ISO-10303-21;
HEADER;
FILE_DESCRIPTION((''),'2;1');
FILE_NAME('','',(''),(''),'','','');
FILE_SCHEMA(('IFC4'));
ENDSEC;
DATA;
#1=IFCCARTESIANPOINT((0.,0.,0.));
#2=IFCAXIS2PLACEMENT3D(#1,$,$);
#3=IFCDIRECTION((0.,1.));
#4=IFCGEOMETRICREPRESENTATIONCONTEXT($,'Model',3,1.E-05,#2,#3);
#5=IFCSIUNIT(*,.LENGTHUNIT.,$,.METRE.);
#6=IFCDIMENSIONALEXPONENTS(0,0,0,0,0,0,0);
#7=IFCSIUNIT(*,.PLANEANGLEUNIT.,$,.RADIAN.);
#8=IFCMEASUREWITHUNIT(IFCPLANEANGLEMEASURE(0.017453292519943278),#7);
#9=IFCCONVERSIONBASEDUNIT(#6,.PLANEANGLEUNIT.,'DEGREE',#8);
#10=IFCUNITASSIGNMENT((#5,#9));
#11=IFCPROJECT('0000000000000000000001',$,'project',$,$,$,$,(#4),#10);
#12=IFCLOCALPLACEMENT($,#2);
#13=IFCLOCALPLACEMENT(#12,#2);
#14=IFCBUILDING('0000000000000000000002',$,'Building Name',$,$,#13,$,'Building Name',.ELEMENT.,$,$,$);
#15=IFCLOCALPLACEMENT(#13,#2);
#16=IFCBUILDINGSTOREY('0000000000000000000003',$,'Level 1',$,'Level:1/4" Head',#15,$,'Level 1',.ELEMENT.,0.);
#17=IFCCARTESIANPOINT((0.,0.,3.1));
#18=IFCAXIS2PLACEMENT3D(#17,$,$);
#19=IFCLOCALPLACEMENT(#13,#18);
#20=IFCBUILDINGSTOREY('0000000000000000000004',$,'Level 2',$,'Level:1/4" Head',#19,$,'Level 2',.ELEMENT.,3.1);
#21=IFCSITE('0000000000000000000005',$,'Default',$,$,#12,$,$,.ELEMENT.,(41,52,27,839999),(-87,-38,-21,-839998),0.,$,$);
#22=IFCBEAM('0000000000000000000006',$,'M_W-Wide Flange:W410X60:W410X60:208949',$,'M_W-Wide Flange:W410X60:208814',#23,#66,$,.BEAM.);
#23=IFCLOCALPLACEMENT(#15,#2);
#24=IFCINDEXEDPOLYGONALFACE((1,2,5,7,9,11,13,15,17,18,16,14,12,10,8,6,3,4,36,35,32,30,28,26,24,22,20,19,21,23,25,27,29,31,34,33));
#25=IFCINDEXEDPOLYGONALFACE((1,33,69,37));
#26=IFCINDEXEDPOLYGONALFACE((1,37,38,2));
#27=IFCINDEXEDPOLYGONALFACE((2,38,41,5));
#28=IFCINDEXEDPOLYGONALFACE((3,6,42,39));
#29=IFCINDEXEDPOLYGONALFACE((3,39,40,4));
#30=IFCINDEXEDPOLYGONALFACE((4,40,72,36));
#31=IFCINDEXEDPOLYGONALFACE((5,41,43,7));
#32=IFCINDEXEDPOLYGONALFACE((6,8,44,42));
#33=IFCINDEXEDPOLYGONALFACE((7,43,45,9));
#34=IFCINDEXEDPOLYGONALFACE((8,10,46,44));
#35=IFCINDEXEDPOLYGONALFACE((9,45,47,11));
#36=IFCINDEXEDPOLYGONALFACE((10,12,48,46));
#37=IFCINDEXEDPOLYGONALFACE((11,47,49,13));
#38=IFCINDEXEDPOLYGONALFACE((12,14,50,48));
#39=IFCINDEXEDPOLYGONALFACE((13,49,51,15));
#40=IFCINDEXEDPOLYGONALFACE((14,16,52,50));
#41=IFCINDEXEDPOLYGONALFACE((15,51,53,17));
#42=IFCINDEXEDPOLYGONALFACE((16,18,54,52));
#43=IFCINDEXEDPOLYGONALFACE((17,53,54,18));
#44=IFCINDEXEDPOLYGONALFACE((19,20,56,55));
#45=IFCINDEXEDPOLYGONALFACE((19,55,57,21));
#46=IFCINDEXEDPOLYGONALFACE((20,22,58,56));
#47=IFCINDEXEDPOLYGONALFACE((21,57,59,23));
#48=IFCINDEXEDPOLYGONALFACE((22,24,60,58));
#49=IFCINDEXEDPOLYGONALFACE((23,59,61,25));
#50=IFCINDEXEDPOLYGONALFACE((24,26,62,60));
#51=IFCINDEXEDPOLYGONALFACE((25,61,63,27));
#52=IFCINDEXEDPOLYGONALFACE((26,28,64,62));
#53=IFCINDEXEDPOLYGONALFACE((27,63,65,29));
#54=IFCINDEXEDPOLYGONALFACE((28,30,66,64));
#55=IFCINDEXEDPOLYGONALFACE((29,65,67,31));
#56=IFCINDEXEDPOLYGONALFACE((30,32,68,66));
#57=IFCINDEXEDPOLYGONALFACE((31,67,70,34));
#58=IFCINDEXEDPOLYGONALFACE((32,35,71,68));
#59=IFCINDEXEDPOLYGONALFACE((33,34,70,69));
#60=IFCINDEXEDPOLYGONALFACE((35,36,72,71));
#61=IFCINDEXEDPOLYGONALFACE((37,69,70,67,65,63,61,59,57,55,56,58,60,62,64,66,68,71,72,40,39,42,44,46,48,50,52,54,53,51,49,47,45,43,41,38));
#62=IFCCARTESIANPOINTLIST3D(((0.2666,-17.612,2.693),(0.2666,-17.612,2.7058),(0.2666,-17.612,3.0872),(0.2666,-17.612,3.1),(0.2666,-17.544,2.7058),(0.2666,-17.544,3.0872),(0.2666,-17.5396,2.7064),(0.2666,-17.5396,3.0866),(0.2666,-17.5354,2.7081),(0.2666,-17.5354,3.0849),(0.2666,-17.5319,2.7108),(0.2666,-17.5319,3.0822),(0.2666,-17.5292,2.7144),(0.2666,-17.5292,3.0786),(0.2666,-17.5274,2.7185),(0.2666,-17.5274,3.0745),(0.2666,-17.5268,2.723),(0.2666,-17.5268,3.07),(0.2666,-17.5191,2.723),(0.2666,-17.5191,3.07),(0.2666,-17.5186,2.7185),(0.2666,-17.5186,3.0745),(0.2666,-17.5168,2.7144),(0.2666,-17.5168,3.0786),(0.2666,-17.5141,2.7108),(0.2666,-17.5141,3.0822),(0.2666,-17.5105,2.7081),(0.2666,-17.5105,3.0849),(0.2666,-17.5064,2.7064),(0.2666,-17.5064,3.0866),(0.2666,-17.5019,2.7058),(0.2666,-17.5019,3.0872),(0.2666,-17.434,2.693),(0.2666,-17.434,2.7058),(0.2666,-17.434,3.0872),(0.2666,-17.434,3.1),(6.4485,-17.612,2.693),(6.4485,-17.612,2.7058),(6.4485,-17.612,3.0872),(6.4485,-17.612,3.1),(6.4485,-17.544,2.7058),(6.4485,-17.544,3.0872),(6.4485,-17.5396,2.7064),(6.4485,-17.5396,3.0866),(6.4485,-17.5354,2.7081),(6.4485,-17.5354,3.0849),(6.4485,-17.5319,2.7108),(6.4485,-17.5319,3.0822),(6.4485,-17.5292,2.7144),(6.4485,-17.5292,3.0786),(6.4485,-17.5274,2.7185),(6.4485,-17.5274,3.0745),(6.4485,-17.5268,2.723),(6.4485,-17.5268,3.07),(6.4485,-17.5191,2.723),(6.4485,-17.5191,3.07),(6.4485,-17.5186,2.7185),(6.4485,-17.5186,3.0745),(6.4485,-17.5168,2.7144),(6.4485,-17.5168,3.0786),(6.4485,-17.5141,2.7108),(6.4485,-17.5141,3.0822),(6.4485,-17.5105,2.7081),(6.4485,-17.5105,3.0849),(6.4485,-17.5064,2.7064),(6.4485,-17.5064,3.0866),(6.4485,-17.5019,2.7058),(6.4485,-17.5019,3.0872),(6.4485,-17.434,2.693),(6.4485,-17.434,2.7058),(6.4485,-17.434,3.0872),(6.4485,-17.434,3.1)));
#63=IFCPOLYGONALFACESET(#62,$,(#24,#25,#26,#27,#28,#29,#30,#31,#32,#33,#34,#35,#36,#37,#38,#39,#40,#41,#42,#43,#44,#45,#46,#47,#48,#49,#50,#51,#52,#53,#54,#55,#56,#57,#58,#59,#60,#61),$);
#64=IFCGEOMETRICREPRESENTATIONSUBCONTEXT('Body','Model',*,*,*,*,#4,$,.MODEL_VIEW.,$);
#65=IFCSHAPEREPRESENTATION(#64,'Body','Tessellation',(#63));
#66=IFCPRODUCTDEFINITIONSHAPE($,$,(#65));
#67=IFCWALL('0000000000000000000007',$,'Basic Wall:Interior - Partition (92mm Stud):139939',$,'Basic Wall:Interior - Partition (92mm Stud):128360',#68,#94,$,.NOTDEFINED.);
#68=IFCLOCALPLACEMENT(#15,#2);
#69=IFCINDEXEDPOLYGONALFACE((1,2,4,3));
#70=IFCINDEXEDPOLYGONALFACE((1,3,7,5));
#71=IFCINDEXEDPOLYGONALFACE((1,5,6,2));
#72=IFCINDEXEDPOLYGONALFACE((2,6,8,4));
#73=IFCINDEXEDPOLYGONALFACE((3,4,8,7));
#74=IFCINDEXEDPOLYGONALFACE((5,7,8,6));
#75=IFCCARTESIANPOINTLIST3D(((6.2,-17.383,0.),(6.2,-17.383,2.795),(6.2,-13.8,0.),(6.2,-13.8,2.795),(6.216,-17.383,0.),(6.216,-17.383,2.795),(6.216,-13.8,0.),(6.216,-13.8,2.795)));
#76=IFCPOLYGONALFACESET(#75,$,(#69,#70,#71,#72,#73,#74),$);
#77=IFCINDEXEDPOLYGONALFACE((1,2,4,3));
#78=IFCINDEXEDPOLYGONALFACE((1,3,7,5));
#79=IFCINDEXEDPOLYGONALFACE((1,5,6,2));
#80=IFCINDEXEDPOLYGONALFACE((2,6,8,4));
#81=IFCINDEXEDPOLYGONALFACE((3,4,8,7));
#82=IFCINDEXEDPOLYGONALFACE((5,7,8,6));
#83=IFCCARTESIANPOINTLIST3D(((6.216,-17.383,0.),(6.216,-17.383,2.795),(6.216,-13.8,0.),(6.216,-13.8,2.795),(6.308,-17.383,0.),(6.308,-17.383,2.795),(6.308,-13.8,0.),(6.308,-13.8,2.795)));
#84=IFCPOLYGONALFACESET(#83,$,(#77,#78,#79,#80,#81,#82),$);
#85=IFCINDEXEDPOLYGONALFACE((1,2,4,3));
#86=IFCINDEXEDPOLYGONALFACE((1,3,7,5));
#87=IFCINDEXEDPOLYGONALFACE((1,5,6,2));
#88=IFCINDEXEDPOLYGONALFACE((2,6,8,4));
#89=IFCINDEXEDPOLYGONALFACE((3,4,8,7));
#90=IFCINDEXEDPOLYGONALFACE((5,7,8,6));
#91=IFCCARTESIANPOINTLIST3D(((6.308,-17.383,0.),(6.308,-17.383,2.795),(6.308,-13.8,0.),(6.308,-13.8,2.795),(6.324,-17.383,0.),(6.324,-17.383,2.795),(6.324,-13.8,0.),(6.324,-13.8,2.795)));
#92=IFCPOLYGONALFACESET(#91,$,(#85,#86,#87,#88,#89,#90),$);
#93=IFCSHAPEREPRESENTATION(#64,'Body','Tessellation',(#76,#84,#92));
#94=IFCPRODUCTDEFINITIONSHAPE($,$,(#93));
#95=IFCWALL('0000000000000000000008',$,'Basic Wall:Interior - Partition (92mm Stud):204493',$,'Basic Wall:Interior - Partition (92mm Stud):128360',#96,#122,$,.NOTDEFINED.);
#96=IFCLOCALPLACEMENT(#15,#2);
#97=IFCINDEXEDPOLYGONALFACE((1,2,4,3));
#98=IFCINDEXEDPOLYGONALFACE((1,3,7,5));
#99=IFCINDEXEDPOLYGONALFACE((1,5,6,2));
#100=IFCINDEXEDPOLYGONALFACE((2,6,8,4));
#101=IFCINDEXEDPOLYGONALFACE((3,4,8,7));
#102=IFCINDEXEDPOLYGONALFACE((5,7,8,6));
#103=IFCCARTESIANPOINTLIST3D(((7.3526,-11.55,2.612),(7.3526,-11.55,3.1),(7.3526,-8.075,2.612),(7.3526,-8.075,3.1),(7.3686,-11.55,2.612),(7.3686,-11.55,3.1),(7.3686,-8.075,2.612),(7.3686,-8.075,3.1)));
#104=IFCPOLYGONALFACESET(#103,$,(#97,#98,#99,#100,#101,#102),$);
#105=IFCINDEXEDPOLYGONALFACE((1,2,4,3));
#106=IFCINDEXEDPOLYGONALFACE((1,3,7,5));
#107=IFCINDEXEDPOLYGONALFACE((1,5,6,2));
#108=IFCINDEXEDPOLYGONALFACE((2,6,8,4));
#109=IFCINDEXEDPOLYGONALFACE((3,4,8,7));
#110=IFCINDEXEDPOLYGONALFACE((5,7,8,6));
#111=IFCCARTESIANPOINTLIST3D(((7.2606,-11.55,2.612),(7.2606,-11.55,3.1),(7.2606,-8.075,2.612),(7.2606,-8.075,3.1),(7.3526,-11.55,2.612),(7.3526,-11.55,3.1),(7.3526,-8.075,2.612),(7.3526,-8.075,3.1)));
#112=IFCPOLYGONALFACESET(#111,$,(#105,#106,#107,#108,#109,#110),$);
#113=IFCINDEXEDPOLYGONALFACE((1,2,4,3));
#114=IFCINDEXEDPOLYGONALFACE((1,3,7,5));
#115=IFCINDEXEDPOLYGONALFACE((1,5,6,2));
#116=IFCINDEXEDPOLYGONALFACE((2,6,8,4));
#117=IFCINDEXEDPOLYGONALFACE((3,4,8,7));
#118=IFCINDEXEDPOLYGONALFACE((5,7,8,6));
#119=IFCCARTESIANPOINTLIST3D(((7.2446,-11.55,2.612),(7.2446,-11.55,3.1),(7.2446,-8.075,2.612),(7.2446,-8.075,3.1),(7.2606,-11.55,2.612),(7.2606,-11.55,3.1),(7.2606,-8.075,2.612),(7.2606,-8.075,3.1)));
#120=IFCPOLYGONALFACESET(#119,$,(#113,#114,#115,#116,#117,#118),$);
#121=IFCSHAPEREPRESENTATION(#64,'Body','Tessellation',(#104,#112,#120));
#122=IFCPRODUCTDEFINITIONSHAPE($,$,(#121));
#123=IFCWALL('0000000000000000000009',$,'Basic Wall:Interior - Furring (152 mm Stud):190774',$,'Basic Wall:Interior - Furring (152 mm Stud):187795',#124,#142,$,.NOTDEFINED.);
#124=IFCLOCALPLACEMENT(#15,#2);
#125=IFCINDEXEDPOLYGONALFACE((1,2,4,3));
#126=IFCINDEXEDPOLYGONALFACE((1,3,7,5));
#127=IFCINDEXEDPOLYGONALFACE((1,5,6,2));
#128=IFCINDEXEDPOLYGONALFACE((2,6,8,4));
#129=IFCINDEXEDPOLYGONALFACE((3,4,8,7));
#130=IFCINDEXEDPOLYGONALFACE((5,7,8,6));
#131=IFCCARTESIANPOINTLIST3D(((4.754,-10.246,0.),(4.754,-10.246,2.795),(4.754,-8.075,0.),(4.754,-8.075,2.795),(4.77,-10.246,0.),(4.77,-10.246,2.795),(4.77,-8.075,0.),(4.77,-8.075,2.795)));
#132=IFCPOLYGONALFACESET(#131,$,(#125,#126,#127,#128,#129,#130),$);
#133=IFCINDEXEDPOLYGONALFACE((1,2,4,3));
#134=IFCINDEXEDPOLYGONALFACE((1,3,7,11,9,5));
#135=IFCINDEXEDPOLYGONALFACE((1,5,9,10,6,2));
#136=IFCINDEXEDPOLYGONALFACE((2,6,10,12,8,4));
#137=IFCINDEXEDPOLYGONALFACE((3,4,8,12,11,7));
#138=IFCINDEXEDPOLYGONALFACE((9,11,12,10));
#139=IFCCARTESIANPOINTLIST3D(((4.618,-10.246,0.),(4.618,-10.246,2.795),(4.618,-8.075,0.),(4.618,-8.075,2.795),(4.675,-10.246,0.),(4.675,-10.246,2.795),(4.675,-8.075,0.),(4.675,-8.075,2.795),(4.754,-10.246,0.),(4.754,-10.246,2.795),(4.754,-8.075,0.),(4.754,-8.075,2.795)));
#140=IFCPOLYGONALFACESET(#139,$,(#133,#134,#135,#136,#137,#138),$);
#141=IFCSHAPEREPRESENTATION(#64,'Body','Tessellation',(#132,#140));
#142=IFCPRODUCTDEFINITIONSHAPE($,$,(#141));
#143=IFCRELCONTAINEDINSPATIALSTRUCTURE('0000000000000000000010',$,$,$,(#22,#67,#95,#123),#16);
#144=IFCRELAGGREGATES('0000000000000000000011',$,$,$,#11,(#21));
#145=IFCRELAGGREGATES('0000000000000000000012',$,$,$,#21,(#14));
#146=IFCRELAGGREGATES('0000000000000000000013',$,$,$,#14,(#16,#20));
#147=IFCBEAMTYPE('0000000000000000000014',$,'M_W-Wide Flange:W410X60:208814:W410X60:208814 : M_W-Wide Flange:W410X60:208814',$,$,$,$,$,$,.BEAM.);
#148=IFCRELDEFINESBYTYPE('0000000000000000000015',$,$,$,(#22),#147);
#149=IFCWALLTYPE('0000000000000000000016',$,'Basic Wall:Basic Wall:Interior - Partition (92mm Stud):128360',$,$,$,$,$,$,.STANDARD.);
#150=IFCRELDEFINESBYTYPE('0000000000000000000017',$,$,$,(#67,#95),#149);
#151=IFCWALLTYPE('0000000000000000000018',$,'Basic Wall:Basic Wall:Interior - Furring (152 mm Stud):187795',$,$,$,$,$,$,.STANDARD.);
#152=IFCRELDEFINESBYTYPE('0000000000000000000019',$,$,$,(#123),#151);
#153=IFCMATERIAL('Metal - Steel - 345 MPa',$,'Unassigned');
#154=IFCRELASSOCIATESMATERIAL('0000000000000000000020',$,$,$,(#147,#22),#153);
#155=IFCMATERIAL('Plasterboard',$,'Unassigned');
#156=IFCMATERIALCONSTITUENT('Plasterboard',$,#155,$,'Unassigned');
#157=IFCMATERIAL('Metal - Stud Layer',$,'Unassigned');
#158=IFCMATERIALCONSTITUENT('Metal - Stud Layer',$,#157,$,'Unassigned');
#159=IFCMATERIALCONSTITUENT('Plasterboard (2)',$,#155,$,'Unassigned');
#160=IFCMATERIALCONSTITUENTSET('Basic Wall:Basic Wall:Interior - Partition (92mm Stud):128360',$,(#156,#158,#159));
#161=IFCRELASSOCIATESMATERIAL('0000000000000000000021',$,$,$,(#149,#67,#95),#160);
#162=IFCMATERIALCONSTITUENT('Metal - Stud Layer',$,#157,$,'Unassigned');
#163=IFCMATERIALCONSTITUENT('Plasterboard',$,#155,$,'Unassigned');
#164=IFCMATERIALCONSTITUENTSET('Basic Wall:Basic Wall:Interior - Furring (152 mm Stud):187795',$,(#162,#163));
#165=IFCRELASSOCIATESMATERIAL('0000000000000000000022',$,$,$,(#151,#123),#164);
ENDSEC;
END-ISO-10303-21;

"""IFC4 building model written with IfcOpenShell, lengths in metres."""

from ifc_helpers import new_model, entity, si_unit, converted_unit, direction, frame, origin, place, context, subcontext, project, spatial, line, arc, indexed_curve, outline, extrude, source, transform, mapped, material, constituent, constituent_set, type_object, type_shapes, element, save


model = new_model("IFC4")

# Units and contexts
model_context = context("Model", 3, precision=1e-05, world=origin(), true_north=direction((0.0, 1.0)))
body_context = subcontext(model_context, "Body", "Model", "MODEL_VIEW")
ifc_project = project(units=[si_unit("LENGTHUNIT", "METRE"), converted_unit("PLANEANGLEUNIT", "DEGREE", entity("IfcPlaneAngleMeasure", 0.017453292519943278), si_unit("PLANEANGLEUNIT", "RADIAN"), dimensions=[0, 0, 0, 0, 0, 0, 0])], contexts=[model_context])

# Site, building, storey
site_placement = place(None, origin())
site = spatial("IfcSite", under=ifc_project, at=site_placement, Name="Default", CompositionType="ELEMENT", RefLatitude=(41, 52, 27, 839999), RefLongitude=(-87, -38, -21, -839998), RefElevation=0.0)
building_placement = place(site_placement, origin())
building = spatial("IfcBuilding", under=site, at=building_placement, Name="Building Name", LongName="Building Name", CompositionType="ELEMENT")
storey_1_placement = place(building_placement, origin())
storey_1 = spatial("IfcBuildingStorey", under=building, at=storey_1_placement, Name="Level 1", ObjectType="Level:1/4\" Head", LongName="Level 1", CompositionType="ELEMENT", Elevation=0.0)

# Beam
ifc_material_1 = material(Name="Metal - Steel - 345 MPa", Category="Unassigned")
beam_type = type_object("IfcBeamType", Name="M_W-Wide Flange:W410X60:208814:W410X60:208814 : M_W-Wide Flange:W410X60:208814", PredefinedType="BEAM", material=ifc_material_1)
shared_shape_1 = source(origin(), body_context, "Body", "SweptSolid", [
    extrude(outline(indexed_curve([(-0.0211, -0.1907), (-0.089, -0.1907), (-0.089, -0.2035), (0.089, -0.2035), (0.089, -0.1907), (0.021, -0.1907), (0.0089, -0.1857), (0.0039, -0.1735), (0.0038, 0.1735), (0.0089, 0.1857), (0.021, 0.1907), (0.089, 0.1907), (0.089, 0.2035), (-0.089, 0.2035), (-0.089, 0.1907), (-0.0211, 0.1907), (-0.0089, 0.1857), (-0.0038, 0.1735), (-0.0039, -0.1735), (-0.0089, -0.1857)], segments=[line(1, 2, 3, 4, 5, 6), arc(6, 7, 8), line(8, 9), arc(9, 10, 11), line(11, 12, 13, 14, 15, 16), arc(16, 17, 18), line(18, 19), arc(19, 20, 1)], self_intersect=False)), frame((0.0, 0.0581, -0.2035), z_axis=(0.0, -1.0, 0.0), x_axis=(1.0, 0.0, 0.0)), (0.0, 0.0, -1.0), 6.1819),
])
type_shapes(beam_type, [shared_shape_1])
beam_placement = place(storey_1_placement, frame((0.2085, -17.523, 3.1), z_axis=(0.0, 0.0, 1.0), x_axis=(0.0, -1.0, 0.0)))
element("IfcBeam", 1, at=beam_placement, inside=storey_1, type_object=beam_type, material=ifc_material_1, Name="M_W-Wide Flange:W410X60:W410X60:208949", ObjectType="M_W-Wide Flange:W410X60:208814", PredefinedType="BEAM", context=body_context, shape_type="MappedRepresentation", body=[
    mapped(shared_shape_1, transform((0.0, 0.0, 0.0), scale=1.0)),
])

# Shared definitions
ifc_material_2 = material(Name="Plasterboard", Category="Unassigned")
ifc_material_3 = material(Name="Metal - Stud Layer", Category="Unassigned")

# Shared definitions
ifc_constituent_1 = constituent(ifc_material_2, Name="Plasterboard", Category="Unassigned")
ifc_constituent_2 = constituent(ifc_material_3, Name="Metal - Stud Layer", Category="Unassigned")
ifc_constituent_3 = constituent(ifc_material_2, Name="Plasterboard (2)", Category="Unassigned")
ifc_constituent_set_1 = constituent_set(constituents=[ifc_constituent_1, ifc_constituent_2, ifc_constituent_3], Name="Basic Wall:Basic Wall:Interior - Partition (92mm Stud):128360")
wall_type_1 = type_object("IfcWallType", Name="Basic Wall:Basic Wall:Interior - Partition (92mm Stud):128360", PredefinedType="STANDARD", material=ifc_constituent_set_1)

# Shared definitions
storey_2_placement = place(building_placement, frame((0.0, 0.0, 3.1)))
storey_2 = spatial("IfcBuildingStorey", under=building, at=storey_2_placement, Name="Level 2", ObjectType="Level:1/4\" Head", LongName="Level 2", CompositionType="ELEMENT", Elevation=3.1)

# Walls
wall_1_placement = place(storey_1_placement, frame((6.262, -13.8, 0.0), z_axis=(0.0, 0.0, 1.0), x_axis=(0.0, -1.0, 0.0)))
element("IfcWall", 2, at=wall_1_placement, inside=storey_1, type_object=wall_type_1, material=ifc_constituent_set_1, Name="Basic Wall:Interior - Partition (92mm Stud):139939", ObjectType="Basic Wall:Interior - Partition (92mm Stud):128360", PredefinedType="NOTDEFINED", context=body_context, shape_type="SweptSolid", body=[
    extrude(outline(indexed_curve([(-0.008, -1.7915), (0.008, -1.7915), (0.008, 1.7915), (-0.008, 1.7915), (-0.008, -1.7915)], self_intersect=False)), frame((1.7915, -0.054, 0.0), z_axis=(0.0, 0.0, 1.0), x_axis=(0.0, 1.0, 0.0)), (0.0, 0.0, 1.0), 2.795),
    extrude(outline(indexed_curve([(-1.7915, -0.046), (1.7915, -0.046), (1.7915, 0.046), (-1.7915, 0.046), (-1.7915, -0.046)], self_intersect=False)), frame((1.7915, 0.0, 0.0)), (0.0, 0.0, 1.0), 2.795),
    extrude(outline(indexed_curve([(-0.008, -1.7915), (0.008, -1.7915), (0.008, 1.7915), (-0.008, 1.7915), (-0.008, -1.7915)], self_intersect=False)), frame((1.7915, 0.054, 0.0), z_axis=(0.0, 0.0, 1.0), x_axis=(0.0, -1.0, 0.0)), (0.0, 0.0, 1.0), 2.795),
])
wall_2_placement = place(storey_1_placement, frame((7.3066, -11.55, 2.612), z_axis=(0.0, 0.0, 1.0), x_axis=(0.0, 1.0, 0.0)))
element("IfcWall", 3, at=wall_2_placement, inside=storey_1, type_object=wall_type_1, material=ifc_constituent_set_1, Name="Basic Wall:Interior - Partition (92mm Stud):204493", ObjectType="Basic Wall:Interior - Partition (92mm Stud):128360", PredefinedType="NOTDEFINED", context=body_context, shape_type="SweptSolid", body=[
    extrude(outline(indexed_curve([(-0.008, -1.7375), (0.008, -1.7375), (0.008, 1.7375), (-0.008, 1.7375), (-0.008, -1.7375)], self_intersect=False)), frame((1.7375, -0.054, 0.0), z_axis=(0.0, 0.0, 1.0), x_axis=(0.0, 1.0, 0.0)), (0.0, 0.0, 1.0), 0.488),
    extrude(outline(indexed_curve([(-0.046, -1.7375), (0.046, -1.7375), (0.046, 1.7375), (-0.046, 1.7375), (-0.046, -1.7375)], self_intersect=False)), frame((1.7375, 0.0, 0.0), z_axis=(0.0, 0.0, 1.0), x_axis=(0.0, 1.0, 0.0)), (0.0, 0.0, 1.0), 0.488),
    extrude(outline(indexed_curve([(-0.008, -1.7375), (0.008, -1.7375), (0.008, 1.7375), (-0.008, 1.7375), (-0.008, -1.7375)], self_intersect=False)), frame((1.7375, 0.054, 0.0), z_axis=(0.0, 0.0, 1.0), x_axis=(0.0, 1.0, 0.0)), (0.0, 0.0, 1.0), 0.488),
])

# Wall
ifc_constituent_4 = constituent(ifc_material_3, Name="Metal - Stud Layer", Category="Unassigned")
ifc_constituent_5 = constituent(ifc_material_2, Name="Plasterboard", Category="Unassigned")
ifc_constituent_set_2 = constituent_set(constituents=[ifc_constituent_4, ifc_constituent_5], Name="Basic Wall:Basic Wall:Interior - Furring (152 mm Stud):187795")
wall_type_2 = type_object("IfcWallType", Name="Basic Wall:Basic Wall:Interior - Furring (152 mm Stud):187795", PredefinedType="STANDARD", material=ifc_constituent_set_2)
wall_3_placement = place(storey_1_placement, frame((4.694, -10.246, 0.0), z_axis=(0.0, 0.0, 1.0), x_axis=(0.0, 1.0, 0.0)))
element("IfcWall", 4, at=wall_3_placement, inside=storey_1, type_object=wall_type_2, material=ifc_constituent_set_2, Name="Basic Wall:Interior - Furring (152 mm Stud):190774", ObjectType="Basic Wall:Interior - Furring (152 mm Stud):187795", PredefinedType="NOTDEFINED", context=body_context, shape_type="SweptSolid", body=[
    extrude(outline(indexed_curve([(-0.008, -1.0855), (0.008, -1.0855), (0.008, 1.0855), (-0.008, 1.0855), (-0.008, -1.0855)], self_intersect=False)), frame((1.0855, -0.068, 0.0), z_axis=(0.0, 0.0, 1.0), x_axis=(0.0, 1.0, 0.0)), (0.0, 0.0, 1.0), 2.795),
    extrude(outline(indexed_curve([(-0.0643, -1.0855), (-0.0073, -1.0855), (0.0717, -1.0855), (0.0717, 1.0855), (-0.0073, 1.0855), (-0.0643, 1.0855), (-0.0643, -1.0855)], self_intersect=False)), frame((1.0855, 0.0117, 0.0), z_axis=(0.0, 0.0, 1.0), x_axis=(0.0, -1.0, 0.0)), (0.0, 0.0, 1.0), 2.795),
])

save(model, "model.ifc")
